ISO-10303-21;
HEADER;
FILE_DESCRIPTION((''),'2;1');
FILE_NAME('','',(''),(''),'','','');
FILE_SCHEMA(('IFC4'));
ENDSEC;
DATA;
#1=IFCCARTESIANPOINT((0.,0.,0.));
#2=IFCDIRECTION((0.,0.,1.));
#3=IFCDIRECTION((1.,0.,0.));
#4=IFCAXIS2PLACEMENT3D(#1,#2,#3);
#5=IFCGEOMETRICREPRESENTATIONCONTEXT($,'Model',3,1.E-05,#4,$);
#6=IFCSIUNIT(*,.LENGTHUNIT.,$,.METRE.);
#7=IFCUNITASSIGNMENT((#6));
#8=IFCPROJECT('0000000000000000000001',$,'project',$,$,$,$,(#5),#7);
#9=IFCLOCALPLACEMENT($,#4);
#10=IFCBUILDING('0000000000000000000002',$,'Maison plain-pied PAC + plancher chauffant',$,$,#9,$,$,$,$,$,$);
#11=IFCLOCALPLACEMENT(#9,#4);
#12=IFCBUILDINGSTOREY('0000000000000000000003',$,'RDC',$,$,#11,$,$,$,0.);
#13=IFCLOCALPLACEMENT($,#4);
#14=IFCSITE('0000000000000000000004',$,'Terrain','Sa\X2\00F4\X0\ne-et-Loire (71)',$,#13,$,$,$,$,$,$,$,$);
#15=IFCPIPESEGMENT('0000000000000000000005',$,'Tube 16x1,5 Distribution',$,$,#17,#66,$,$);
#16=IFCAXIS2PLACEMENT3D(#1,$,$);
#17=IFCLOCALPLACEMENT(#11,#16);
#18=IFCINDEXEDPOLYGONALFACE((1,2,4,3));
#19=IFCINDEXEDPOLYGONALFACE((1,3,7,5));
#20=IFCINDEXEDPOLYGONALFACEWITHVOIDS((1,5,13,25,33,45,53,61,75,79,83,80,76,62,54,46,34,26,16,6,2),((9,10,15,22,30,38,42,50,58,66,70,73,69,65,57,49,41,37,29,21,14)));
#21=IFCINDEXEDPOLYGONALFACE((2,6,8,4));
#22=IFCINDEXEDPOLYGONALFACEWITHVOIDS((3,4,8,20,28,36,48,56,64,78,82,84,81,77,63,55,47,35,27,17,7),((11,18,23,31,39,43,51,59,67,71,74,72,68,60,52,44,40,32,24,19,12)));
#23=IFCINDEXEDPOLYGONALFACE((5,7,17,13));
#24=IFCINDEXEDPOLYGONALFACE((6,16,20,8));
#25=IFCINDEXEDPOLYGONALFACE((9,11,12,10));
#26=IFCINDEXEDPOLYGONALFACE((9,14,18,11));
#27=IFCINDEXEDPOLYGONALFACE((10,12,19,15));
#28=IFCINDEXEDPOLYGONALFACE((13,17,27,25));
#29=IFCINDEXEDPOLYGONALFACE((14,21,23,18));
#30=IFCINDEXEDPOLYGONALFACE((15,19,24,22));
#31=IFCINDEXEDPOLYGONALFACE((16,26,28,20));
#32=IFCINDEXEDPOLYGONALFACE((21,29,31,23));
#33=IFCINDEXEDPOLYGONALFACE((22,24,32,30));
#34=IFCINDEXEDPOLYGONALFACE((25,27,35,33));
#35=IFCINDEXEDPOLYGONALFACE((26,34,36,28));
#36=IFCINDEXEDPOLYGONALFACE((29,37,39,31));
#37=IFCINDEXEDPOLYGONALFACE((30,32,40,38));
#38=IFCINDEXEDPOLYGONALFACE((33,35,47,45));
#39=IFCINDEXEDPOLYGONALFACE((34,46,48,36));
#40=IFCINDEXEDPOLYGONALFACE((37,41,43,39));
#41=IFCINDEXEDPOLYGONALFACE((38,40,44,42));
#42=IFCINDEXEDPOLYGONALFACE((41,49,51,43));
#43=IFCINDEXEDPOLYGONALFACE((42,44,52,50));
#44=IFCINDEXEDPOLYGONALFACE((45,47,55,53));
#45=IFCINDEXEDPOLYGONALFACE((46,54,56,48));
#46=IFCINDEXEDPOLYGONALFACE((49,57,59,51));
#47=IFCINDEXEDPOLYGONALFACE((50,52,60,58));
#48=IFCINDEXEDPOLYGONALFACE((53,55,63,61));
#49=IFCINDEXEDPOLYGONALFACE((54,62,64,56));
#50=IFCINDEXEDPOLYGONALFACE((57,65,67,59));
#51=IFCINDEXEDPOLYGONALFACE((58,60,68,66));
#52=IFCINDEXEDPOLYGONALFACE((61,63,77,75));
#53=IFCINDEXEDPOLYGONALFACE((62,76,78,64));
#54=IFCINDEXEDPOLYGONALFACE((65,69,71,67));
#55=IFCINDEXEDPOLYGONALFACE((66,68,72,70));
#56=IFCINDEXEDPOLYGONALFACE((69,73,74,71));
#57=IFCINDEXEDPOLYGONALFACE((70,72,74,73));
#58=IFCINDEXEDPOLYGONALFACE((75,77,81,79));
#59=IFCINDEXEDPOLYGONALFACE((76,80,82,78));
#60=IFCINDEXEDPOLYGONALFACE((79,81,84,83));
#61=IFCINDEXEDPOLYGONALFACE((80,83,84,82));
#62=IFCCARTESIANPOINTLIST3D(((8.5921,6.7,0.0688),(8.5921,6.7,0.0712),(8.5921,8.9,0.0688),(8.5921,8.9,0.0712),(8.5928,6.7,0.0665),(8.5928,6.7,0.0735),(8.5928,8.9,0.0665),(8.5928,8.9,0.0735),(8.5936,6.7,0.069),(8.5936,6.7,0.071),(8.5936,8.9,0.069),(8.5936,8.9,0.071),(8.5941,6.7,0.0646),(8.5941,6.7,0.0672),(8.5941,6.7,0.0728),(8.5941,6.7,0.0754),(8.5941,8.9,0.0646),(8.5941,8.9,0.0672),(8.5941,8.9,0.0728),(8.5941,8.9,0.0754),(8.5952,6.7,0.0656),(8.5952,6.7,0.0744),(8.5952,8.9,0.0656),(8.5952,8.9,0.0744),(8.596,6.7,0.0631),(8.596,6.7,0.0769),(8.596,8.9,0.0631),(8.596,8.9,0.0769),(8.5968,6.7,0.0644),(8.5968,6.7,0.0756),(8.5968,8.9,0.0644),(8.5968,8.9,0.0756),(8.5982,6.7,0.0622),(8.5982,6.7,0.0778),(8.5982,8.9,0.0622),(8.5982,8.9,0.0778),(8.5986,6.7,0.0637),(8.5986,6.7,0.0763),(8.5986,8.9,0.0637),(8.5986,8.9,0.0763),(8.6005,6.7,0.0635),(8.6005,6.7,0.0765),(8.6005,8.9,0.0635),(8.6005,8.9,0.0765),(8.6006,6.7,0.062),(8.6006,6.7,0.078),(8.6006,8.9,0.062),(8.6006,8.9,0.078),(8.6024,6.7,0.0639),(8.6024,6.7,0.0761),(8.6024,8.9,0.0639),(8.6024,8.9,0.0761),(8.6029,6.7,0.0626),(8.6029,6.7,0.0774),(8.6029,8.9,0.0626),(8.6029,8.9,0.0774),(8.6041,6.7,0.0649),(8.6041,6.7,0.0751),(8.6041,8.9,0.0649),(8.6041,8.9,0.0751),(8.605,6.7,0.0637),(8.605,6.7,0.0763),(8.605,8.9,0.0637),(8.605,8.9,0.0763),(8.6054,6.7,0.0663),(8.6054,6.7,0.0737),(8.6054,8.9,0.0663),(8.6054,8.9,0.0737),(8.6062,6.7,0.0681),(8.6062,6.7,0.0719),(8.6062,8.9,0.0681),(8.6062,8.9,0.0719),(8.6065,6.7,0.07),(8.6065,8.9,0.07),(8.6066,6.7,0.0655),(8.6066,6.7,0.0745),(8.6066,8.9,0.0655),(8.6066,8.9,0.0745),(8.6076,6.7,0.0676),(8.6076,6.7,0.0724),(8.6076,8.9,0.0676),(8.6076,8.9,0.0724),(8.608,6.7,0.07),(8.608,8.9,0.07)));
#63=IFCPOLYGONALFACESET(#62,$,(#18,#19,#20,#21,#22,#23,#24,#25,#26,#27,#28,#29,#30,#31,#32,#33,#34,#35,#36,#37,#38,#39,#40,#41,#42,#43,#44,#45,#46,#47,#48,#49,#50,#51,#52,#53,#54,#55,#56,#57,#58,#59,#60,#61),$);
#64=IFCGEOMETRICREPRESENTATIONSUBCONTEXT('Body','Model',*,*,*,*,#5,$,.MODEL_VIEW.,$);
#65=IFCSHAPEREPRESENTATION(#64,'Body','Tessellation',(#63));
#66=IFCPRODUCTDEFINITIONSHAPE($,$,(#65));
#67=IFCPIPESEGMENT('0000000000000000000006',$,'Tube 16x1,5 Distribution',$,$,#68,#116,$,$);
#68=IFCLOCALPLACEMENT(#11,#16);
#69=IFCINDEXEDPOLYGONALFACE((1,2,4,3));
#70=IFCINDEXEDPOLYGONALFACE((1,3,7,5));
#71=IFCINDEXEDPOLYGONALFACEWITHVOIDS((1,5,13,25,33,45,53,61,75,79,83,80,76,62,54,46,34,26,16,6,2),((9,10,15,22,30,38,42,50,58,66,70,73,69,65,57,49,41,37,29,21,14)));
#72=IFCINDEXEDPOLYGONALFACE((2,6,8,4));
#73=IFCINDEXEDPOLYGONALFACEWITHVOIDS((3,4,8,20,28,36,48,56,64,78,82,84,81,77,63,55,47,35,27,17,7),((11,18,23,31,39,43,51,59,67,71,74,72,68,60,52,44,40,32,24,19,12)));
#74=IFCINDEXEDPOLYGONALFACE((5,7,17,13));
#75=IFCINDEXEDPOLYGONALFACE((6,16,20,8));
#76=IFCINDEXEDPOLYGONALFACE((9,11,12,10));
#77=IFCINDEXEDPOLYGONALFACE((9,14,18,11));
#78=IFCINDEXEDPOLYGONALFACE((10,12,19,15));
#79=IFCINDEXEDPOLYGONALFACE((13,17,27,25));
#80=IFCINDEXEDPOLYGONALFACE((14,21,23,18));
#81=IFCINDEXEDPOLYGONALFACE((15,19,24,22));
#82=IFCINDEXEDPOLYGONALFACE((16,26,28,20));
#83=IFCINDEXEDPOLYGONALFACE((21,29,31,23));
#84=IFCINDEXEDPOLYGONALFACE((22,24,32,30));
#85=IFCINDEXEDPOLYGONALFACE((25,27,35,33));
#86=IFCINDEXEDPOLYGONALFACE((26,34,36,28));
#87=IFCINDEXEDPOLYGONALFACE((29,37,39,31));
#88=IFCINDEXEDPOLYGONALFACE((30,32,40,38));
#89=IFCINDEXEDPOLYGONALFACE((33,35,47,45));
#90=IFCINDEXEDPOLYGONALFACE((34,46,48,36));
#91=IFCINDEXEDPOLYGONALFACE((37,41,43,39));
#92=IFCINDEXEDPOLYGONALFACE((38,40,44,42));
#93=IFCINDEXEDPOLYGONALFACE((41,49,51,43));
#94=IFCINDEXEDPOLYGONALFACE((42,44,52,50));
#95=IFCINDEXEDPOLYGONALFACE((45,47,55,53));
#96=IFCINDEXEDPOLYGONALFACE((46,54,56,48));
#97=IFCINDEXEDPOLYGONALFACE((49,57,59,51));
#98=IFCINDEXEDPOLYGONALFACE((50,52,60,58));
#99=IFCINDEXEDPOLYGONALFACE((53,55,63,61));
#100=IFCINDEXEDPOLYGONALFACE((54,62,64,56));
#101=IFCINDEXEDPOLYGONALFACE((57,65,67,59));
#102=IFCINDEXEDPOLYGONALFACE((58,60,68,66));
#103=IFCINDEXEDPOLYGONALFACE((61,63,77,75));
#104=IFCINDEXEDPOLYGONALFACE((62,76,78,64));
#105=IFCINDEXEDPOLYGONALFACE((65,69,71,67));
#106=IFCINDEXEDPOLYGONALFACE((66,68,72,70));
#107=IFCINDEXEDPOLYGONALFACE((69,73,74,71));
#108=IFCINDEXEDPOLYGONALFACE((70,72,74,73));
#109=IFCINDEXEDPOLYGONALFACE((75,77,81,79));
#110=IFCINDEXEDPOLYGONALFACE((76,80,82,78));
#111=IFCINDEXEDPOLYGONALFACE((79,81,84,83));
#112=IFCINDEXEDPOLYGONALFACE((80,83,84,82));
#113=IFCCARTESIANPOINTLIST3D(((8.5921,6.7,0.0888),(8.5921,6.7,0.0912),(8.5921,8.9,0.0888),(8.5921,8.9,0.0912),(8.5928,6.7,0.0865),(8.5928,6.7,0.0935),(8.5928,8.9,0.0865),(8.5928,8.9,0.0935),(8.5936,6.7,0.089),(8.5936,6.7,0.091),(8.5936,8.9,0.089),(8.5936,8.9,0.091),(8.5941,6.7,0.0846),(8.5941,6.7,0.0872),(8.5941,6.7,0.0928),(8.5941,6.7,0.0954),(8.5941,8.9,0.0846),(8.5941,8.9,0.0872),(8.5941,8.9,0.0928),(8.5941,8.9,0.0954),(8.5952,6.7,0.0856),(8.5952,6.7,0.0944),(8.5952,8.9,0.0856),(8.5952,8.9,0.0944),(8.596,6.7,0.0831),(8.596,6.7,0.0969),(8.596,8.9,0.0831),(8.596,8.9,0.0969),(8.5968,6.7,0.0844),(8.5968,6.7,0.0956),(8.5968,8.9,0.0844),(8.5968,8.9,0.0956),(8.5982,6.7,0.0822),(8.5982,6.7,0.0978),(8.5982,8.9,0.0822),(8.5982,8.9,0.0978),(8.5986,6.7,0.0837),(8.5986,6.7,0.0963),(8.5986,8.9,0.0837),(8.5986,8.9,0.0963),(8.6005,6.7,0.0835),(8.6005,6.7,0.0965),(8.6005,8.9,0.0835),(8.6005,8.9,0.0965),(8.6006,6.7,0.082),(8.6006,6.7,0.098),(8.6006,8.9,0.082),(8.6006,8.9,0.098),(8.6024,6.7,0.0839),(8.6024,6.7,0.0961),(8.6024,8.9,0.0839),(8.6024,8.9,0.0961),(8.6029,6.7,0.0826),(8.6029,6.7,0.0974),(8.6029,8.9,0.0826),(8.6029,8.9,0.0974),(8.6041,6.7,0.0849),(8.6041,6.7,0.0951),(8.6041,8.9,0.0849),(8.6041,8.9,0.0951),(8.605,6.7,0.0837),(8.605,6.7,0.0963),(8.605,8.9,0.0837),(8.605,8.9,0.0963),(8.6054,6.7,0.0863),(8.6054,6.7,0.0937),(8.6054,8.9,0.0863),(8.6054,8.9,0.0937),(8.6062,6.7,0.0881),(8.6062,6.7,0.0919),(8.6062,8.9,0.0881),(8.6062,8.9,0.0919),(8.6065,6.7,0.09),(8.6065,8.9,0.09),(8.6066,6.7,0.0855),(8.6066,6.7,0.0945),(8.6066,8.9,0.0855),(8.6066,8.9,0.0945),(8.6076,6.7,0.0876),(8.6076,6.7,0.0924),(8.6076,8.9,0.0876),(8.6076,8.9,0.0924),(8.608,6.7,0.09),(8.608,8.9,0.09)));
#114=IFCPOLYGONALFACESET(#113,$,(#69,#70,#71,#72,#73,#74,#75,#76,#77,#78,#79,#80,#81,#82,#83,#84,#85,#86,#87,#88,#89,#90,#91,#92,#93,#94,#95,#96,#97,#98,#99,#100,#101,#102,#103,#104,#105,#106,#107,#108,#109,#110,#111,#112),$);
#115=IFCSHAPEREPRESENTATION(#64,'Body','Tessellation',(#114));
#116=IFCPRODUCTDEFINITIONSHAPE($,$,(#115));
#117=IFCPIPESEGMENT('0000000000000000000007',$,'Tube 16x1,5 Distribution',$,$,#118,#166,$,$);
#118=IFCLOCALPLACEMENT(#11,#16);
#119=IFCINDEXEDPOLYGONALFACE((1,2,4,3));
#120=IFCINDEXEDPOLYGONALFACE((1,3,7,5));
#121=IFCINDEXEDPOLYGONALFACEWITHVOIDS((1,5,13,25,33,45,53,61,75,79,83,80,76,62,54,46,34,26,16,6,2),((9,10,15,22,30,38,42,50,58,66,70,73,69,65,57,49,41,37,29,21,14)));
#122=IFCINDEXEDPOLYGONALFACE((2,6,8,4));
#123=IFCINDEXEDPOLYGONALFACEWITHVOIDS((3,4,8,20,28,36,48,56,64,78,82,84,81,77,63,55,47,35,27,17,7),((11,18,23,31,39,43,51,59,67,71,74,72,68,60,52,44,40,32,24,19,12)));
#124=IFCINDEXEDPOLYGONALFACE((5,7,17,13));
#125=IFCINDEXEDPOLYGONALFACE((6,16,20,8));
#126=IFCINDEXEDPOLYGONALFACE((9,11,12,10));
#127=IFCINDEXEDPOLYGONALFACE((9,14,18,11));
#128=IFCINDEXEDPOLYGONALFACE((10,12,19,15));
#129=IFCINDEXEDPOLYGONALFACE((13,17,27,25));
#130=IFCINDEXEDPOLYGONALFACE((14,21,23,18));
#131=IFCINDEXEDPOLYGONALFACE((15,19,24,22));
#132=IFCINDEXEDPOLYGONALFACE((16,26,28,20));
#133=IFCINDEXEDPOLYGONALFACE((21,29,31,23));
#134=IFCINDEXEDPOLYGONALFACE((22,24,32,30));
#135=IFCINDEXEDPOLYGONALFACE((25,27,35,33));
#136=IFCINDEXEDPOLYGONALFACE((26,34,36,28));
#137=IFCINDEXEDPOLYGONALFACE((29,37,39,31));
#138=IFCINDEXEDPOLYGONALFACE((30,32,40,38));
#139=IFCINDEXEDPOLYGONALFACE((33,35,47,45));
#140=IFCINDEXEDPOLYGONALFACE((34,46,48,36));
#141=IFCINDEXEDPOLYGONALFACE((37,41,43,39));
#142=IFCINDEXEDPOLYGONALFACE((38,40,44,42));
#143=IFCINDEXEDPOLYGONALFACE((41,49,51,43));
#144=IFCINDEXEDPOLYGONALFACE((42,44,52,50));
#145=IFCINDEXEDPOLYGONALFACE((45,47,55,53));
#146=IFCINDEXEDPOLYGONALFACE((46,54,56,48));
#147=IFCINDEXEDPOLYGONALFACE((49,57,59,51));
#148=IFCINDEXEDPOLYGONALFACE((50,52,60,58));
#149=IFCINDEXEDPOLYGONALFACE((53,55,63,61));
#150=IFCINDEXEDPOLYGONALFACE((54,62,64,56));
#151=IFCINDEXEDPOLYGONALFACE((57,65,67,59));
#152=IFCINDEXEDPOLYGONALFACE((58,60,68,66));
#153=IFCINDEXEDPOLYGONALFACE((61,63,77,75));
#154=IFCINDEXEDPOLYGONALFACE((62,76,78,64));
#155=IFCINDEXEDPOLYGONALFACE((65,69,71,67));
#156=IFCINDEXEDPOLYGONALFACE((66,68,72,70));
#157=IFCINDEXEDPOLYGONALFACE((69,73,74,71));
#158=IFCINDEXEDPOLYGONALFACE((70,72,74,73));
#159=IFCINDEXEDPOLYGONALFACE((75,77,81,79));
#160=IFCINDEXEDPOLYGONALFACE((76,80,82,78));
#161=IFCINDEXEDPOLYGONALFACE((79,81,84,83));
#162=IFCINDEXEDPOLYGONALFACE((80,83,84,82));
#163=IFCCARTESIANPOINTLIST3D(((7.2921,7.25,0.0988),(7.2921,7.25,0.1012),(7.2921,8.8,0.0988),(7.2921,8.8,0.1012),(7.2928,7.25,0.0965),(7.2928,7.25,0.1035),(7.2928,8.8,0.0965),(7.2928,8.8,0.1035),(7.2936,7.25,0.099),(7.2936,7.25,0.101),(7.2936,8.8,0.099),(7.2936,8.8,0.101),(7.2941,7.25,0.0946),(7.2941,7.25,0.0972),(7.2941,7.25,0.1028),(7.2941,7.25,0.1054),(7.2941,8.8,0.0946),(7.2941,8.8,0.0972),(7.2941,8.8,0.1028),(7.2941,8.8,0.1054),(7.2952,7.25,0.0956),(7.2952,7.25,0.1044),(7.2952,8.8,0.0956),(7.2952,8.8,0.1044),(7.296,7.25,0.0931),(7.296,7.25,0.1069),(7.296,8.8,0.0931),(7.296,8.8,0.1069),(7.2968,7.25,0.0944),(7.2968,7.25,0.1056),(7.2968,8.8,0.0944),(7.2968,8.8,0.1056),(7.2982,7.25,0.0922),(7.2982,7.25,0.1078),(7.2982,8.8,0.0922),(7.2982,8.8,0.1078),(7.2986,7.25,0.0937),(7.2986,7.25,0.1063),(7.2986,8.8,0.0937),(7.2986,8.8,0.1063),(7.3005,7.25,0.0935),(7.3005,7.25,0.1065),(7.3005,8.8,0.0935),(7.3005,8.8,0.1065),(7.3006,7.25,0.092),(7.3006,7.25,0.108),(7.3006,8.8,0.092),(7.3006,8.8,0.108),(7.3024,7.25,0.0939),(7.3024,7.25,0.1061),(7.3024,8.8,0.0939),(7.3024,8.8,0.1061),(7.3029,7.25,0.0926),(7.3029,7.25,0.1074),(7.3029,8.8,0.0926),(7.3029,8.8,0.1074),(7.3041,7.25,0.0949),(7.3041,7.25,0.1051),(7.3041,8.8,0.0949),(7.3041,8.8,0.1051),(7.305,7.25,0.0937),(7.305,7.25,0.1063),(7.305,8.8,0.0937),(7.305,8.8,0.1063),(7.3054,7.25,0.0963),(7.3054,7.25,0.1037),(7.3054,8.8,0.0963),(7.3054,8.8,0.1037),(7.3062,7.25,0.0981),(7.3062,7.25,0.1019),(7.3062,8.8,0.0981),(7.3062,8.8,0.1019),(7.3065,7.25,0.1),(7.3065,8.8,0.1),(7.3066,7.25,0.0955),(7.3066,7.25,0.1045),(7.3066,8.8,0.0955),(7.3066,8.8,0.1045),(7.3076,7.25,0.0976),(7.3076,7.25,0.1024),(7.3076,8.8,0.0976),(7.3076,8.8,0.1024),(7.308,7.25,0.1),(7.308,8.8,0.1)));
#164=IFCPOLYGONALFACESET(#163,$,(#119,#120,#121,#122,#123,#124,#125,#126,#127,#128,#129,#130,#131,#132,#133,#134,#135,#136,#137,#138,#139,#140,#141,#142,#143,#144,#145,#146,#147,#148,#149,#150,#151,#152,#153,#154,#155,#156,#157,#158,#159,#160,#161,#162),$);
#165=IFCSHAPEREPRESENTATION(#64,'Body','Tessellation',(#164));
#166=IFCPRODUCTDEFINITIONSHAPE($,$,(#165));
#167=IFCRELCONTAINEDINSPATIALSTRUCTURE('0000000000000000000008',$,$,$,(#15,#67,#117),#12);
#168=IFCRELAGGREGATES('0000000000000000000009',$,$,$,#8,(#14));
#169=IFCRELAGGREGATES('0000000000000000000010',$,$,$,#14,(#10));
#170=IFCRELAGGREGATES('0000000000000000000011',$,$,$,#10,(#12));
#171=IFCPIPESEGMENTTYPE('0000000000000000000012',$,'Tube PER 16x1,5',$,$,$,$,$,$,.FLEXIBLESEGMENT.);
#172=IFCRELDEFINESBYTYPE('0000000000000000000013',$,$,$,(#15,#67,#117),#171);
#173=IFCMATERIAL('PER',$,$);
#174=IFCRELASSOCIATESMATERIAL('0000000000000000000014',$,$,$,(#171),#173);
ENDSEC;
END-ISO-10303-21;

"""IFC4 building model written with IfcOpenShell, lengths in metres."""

from ifc_helpers import new_model, si_unit, frame, origin_with_axes, place, context, subcontext, project, spatial, hollow_circle, extrude, material, type_object, element, save


model = new_model("IFC4")

# Units and contexts
model_context = context("Model", 3, precision=1e-05, world=origin_with_axes())
body_context = subcontext(model_context, "Body", "Model", "MODEL_VIEW")
ifc_project = project(units=[si_unit("LENGTHUNIT", "METRE")], contexts=[model_context])

# Site, building, storey
site_placement = place(None, origin_with_axes())
site = spatial("IfcSite", under=ifc_project, at=site_placement, Name="Terrain", Description="Saône-et-Loire (71)")
building_placement = place(None, origin_with_axes())
building = spatial("IfcBuilding", under=site, at=building_placement, Name="Maison plain-pied PAC + plancher chauffant")
storey_placement = place(building_placement, origin_with_axes())
storey = spatial("IfcBuildingStorey", under=building, at=storey_placement, Name="RDC", Elevation=0.0)

# Pipe segments
ifc_material_1 = material(Name="PER")
pipe_segment_type_1 = type_object("IfcPipeSegmentType", Name="Tube PER 16x1,5", PredefinedType="FLEXIBLESEGMENT", material=ifc_material_1)
for number, where, z_axis, x_axis, name in (
    (1, (8.6, 6.7, 0.07), (0.0, 1.0, 0.0), (1.0, 0.0, 0.0), "Tube 16x1,5 Distribution"),
    (2, (8.6, 6.7, 0.09), (0.0, 1.0, 0.0), (1.0, 0.0, 0.0), "Tube 16x1,5 Distribution"),
):
    element("IfcPipeSegment", number, at=place(storey_placement, frame(where, z_axis=z_axis, x_axis=x_axis)), inside=storey, type_object=pipe_segment_type_1, Name=name, context=body_context, shape_type="SweptSolid", body=[
        extrude(hollow_circle(Radius=0.008, WallThickness=0.0015), origin_with_axes(), (0.0, 0.0, 1.0), 2.2),
    ])
pipe_segment_1_placement = place(storey_placement, frame((7.3, 7.25, 0.1), z_axis=(0.0, 1.0, 0.0), x_axis=(1.0, 0.0, 0.0)))
element("IfcPipeSegment", 3, at=pipe_segment_1_placement, inside=storey, type_object=pipe_segment_type_1, Name="Tube 16x1,5 Distribution", context=body_context, shape_type="SweptSolid", body=[
    extrude(hollow_circle(Radius=0.008, WallThickness=0.0015), origin_with_axes(), (0.0, 0.0, 1.0), 1.55),
])

save(model, "model.ifc")
